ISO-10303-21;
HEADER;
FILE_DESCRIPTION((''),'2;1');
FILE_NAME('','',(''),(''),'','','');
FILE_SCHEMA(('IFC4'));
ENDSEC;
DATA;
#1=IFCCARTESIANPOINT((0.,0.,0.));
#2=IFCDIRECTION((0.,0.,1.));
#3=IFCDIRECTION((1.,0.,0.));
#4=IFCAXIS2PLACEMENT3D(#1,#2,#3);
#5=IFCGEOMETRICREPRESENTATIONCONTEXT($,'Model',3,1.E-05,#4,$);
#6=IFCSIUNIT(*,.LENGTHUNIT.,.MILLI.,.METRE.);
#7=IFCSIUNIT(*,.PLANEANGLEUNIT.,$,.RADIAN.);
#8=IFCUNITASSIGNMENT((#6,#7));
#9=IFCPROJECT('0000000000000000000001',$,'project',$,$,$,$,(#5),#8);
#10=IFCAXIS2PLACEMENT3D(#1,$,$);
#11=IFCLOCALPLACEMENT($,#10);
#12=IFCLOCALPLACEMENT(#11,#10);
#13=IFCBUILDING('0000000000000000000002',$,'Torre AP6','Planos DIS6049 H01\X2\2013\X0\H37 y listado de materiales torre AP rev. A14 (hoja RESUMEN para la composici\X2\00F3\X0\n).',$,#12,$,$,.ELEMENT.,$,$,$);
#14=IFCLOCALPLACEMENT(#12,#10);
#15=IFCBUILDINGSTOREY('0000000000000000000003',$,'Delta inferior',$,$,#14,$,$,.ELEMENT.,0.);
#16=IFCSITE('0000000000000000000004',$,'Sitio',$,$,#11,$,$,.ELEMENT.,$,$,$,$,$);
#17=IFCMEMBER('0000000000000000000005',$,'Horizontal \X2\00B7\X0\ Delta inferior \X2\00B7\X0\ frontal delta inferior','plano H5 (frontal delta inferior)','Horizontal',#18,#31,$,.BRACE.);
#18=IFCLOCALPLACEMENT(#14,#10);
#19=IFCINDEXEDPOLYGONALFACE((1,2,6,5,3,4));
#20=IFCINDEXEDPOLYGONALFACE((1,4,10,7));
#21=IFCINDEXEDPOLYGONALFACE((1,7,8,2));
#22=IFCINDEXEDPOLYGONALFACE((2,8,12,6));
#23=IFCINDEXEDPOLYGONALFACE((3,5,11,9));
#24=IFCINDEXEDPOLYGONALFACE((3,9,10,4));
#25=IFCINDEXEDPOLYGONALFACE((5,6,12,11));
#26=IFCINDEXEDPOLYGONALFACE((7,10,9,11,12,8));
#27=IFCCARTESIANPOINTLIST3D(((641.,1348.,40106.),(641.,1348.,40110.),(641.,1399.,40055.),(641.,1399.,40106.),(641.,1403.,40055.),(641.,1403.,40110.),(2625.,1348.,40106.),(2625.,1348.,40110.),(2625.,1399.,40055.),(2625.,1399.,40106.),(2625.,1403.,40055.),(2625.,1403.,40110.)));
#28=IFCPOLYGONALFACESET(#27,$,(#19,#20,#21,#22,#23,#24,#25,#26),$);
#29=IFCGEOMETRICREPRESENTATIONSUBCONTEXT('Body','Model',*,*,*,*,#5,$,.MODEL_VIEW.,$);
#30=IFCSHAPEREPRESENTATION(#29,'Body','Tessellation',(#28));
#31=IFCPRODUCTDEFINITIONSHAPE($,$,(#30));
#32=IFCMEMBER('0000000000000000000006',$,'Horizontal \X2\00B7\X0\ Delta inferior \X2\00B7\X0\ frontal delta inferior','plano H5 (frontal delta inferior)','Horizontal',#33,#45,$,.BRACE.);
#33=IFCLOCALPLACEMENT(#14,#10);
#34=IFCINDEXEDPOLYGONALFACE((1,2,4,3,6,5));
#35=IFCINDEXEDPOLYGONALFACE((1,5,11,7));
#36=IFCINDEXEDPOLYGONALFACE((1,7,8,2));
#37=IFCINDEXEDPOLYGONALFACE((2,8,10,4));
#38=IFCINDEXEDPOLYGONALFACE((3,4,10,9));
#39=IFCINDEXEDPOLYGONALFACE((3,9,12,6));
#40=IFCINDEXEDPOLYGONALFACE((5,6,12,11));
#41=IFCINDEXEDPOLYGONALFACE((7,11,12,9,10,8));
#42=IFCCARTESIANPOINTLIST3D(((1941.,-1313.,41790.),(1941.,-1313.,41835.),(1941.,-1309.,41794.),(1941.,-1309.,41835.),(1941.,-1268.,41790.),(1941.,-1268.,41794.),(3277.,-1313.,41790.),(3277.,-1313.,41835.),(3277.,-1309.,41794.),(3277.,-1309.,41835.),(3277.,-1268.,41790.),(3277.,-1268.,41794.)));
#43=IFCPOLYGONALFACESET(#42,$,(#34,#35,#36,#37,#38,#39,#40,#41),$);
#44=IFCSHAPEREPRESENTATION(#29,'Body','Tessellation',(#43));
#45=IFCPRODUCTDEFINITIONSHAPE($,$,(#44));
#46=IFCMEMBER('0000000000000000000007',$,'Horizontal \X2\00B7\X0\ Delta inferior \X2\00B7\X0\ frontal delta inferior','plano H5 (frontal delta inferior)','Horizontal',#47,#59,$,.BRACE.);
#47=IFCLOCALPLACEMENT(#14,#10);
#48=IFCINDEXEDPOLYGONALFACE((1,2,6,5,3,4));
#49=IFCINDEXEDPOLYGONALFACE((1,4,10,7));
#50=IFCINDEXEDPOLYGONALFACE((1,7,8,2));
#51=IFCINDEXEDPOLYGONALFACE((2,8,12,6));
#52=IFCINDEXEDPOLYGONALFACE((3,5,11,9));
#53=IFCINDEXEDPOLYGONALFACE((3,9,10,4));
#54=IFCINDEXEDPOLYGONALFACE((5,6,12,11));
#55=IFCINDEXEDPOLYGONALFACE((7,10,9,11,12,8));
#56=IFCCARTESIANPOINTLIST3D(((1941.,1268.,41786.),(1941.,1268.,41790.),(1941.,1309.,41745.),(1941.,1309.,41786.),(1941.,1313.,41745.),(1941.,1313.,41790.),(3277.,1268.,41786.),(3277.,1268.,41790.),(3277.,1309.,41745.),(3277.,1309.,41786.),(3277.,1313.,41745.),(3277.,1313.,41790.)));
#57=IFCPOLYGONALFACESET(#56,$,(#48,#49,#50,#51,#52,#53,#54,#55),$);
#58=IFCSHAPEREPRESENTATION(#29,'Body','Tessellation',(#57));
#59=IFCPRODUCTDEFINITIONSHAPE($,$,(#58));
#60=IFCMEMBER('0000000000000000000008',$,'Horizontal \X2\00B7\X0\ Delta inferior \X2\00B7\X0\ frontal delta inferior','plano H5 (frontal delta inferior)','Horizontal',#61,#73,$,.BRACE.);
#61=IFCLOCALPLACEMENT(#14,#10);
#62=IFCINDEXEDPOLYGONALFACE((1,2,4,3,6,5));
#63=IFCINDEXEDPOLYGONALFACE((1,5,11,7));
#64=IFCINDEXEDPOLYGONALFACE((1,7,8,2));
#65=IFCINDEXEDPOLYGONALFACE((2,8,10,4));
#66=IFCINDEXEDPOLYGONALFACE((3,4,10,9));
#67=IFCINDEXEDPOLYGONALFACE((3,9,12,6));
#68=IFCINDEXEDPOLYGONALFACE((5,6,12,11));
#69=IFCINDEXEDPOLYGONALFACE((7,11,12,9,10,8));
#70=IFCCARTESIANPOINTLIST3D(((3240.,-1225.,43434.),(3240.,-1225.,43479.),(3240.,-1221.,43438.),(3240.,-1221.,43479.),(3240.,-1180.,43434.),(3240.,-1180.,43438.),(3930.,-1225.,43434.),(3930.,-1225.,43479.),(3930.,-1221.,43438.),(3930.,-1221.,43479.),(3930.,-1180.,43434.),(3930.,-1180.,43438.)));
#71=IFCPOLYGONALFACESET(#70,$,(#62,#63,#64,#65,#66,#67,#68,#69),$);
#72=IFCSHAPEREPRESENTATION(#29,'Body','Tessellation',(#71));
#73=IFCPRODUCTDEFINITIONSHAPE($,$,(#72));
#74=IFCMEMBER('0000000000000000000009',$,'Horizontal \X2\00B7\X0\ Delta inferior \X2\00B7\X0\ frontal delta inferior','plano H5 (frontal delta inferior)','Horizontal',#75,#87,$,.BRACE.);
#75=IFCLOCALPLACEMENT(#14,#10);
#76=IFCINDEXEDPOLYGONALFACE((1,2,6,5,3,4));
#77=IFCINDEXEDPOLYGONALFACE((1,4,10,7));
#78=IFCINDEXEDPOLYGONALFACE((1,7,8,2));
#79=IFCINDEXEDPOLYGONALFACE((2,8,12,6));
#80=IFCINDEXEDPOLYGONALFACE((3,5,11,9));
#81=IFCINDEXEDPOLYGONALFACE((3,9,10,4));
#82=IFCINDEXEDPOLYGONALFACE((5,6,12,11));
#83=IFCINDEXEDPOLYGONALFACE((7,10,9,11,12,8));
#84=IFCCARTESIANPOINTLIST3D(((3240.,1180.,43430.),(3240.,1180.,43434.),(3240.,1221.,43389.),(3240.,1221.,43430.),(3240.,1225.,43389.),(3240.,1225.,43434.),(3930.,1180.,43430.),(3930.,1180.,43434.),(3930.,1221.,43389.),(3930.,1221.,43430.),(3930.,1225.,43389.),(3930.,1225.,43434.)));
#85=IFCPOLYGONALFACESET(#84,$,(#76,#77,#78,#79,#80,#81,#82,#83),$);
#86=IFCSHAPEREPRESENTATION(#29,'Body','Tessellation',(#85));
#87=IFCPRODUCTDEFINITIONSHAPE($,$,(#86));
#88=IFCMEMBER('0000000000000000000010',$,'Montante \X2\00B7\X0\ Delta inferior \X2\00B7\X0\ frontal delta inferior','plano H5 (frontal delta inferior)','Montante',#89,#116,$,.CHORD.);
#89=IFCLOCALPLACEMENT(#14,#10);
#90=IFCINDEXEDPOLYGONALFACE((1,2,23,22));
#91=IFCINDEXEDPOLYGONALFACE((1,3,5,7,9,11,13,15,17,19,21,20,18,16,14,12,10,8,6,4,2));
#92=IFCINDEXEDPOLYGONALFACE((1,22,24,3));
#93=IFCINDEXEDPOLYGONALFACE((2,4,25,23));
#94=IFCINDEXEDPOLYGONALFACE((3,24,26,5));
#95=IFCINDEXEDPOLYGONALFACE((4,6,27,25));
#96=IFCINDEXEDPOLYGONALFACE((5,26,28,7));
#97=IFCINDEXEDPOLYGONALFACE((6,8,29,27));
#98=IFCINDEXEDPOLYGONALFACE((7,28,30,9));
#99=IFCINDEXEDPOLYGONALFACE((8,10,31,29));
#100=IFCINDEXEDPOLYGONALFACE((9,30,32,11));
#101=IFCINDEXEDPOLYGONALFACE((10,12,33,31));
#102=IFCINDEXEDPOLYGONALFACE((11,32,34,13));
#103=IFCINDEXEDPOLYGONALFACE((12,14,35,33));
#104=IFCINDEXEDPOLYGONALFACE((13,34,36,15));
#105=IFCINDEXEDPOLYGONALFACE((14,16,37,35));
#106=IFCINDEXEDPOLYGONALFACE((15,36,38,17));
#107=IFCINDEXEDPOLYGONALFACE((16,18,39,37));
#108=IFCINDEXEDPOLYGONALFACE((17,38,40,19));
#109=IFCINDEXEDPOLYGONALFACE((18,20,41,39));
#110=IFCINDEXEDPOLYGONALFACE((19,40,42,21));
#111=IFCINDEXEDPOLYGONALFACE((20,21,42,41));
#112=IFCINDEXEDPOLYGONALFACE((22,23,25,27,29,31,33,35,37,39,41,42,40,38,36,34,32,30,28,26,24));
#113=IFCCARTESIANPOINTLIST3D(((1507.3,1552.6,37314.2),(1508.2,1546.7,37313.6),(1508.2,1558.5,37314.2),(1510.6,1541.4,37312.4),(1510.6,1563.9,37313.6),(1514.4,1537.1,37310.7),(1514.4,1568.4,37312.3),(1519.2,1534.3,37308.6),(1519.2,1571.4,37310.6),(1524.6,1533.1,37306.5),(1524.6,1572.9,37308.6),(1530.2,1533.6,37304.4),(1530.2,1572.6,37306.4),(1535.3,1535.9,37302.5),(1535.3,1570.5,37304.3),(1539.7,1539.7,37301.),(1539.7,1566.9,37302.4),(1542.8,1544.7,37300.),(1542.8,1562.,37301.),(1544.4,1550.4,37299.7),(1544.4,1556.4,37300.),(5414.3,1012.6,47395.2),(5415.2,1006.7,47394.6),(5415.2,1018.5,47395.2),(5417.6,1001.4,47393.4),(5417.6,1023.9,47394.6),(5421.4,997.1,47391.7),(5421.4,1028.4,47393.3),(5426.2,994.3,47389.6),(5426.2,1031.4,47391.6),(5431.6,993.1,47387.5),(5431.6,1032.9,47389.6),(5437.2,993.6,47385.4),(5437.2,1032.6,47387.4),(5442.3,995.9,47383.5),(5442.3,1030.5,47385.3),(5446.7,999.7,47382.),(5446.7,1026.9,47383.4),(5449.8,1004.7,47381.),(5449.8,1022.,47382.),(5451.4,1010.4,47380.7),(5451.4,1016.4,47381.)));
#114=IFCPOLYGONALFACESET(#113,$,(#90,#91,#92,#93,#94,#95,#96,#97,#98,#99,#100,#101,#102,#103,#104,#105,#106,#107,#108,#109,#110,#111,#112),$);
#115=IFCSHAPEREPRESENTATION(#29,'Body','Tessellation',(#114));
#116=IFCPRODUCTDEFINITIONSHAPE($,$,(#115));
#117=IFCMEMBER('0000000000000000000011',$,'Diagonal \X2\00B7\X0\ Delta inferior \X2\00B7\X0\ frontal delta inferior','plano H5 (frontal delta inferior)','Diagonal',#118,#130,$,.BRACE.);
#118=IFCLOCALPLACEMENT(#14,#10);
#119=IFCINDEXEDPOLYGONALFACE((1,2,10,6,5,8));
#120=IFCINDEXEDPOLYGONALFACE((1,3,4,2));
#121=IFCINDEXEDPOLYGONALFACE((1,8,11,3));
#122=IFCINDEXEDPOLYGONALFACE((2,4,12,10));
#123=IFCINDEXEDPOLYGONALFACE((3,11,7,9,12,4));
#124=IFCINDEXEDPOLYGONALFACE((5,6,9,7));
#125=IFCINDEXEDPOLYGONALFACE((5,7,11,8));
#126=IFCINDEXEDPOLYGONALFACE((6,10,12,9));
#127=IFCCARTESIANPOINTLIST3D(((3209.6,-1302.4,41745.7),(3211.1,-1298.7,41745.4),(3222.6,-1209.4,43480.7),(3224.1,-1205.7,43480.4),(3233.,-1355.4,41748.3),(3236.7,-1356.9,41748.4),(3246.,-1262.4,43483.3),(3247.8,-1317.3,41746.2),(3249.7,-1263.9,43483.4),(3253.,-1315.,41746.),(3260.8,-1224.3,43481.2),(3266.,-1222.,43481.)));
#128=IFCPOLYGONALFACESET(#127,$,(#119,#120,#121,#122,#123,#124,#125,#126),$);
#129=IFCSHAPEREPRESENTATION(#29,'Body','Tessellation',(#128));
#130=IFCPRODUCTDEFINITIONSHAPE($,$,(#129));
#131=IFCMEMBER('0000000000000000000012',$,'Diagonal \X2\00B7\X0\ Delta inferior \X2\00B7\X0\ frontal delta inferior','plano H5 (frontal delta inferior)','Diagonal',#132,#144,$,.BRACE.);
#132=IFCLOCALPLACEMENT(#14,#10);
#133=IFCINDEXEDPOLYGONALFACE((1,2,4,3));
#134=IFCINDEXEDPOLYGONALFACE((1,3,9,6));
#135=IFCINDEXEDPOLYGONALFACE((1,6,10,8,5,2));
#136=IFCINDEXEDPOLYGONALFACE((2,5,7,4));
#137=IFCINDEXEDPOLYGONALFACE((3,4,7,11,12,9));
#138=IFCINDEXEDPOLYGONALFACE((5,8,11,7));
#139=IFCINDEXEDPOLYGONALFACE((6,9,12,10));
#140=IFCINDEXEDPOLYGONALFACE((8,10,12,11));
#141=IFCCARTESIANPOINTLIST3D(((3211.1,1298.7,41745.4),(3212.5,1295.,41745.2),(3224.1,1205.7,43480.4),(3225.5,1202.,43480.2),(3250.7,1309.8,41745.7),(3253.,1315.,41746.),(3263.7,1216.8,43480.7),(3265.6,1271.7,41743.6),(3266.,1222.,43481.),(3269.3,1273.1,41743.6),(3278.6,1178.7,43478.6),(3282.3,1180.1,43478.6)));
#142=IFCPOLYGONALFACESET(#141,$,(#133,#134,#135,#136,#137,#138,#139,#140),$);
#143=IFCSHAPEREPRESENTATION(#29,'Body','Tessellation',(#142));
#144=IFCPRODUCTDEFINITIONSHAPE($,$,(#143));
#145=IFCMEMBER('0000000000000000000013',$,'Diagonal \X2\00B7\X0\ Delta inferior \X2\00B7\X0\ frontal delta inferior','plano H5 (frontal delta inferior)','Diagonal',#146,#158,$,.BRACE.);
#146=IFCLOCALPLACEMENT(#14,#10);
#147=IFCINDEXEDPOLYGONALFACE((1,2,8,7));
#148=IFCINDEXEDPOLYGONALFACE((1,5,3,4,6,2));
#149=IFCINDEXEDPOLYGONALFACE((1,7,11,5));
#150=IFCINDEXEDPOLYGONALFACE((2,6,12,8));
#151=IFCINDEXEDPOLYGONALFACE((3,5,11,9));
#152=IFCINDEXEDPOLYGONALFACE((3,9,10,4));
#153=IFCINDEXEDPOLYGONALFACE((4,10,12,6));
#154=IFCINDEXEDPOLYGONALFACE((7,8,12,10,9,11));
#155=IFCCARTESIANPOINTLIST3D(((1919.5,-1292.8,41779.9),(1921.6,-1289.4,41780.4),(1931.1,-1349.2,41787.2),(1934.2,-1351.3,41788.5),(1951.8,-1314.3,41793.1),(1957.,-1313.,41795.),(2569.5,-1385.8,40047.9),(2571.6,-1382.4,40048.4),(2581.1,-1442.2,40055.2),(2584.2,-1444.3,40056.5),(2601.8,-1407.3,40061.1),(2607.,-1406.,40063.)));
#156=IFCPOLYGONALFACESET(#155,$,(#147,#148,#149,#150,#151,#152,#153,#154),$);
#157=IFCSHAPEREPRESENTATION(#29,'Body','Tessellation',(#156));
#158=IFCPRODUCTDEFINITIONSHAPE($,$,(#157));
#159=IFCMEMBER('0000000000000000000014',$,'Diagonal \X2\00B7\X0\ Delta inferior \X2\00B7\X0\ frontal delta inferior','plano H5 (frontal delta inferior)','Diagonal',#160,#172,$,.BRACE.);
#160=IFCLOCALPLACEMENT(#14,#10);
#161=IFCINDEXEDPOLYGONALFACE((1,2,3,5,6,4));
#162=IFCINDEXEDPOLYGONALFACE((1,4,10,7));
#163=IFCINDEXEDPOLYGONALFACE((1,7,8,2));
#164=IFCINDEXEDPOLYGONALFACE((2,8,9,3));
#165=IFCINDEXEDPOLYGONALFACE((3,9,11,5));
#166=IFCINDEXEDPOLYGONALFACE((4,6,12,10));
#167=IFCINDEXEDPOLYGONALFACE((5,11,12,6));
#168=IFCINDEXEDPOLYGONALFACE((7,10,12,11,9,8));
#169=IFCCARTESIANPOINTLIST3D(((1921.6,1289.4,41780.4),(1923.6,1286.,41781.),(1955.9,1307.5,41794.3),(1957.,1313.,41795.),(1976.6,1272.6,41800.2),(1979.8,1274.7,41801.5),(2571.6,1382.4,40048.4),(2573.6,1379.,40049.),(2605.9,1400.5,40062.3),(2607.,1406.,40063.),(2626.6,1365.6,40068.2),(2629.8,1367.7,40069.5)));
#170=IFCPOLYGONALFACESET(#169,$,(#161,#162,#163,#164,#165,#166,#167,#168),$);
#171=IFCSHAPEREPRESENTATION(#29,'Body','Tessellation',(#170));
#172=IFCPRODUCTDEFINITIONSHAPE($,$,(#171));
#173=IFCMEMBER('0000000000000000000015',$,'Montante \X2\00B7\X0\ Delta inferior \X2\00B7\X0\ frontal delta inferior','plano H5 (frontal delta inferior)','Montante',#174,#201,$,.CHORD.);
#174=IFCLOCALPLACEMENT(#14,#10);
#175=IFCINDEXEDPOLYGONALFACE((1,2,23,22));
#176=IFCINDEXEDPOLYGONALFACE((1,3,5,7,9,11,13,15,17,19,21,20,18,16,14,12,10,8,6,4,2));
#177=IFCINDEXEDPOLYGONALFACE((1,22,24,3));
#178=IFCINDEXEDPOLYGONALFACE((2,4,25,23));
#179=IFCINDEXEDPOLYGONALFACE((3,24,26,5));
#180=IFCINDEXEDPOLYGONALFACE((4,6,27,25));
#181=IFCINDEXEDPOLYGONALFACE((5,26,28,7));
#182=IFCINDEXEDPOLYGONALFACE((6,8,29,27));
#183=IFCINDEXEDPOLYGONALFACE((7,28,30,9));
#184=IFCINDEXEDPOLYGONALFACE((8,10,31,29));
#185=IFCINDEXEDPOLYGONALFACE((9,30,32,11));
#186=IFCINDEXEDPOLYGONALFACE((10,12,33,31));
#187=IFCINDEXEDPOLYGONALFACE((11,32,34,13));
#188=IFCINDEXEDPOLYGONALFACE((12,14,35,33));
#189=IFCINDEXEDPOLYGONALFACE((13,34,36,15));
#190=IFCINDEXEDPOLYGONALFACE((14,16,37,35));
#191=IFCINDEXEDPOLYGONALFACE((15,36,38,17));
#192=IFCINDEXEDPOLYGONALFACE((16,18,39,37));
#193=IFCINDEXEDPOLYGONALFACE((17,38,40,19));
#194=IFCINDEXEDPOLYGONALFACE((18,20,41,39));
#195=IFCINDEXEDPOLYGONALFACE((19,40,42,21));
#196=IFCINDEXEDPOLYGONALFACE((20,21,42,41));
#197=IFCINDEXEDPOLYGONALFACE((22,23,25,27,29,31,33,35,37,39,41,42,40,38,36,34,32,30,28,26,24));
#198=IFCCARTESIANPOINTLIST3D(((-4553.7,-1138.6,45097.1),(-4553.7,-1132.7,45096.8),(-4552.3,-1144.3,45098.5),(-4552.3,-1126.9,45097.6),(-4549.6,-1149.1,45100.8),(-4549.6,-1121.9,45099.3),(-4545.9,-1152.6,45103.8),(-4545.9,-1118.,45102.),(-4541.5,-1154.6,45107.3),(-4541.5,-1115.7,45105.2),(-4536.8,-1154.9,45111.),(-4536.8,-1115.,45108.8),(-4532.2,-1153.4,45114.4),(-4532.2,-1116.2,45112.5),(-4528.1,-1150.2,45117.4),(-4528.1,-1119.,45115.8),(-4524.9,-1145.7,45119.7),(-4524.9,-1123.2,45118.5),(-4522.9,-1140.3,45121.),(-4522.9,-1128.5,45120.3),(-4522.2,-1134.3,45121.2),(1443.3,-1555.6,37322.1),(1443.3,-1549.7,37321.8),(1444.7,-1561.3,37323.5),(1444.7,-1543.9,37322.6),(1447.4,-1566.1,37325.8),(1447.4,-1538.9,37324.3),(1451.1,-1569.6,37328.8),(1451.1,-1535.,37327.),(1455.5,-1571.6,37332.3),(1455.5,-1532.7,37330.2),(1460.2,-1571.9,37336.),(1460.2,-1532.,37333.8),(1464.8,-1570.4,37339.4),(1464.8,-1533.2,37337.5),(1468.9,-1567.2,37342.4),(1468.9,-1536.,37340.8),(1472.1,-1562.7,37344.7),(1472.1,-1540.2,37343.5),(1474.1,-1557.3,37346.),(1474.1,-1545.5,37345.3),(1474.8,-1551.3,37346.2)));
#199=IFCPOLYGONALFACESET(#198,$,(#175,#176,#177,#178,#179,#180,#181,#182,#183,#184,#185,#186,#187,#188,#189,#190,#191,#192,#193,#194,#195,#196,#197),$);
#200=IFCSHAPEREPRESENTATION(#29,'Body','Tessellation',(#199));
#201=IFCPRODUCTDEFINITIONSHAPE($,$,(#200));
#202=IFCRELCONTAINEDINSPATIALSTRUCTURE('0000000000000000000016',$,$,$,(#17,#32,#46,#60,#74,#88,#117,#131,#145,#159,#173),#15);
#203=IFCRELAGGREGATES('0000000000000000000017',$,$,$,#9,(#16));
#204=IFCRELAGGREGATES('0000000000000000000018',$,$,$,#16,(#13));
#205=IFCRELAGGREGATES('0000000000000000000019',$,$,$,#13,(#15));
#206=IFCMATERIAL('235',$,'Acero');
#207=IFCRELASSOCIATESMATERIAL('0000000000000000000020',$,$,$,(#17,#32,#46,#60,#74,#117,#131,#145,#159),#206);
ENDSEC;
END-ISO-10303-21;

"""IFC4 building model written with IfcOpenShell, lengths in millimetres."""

from ifc_helpers import new_model, si_unit, frame, frame_2d, origin, origin_with_axes, place, context, subcontext, project, spatial, circle, l_section, extrude, material, element, save


model = new_model("IFC4")

# Units and contexts
model_context = context("Model", 3, precision=1e-05, world=origin_with_axes())
body_context = subcontext(model_context, "Body", "Model", "MODEL_VIEW")
ifc_project = project(units=[si_unit("LENGTHUNIT", "METRE", prefix="MILLI"), si_unit("PLANEANGLEUNIT", "RADIAN")], contexts=[model_context])

# Site, building, storey
site_placement = place(None, origin())
site = spatial("IfcSite", under=ifc_project, at=site_placement, Name="Sitio", CompositionType="ELEMENT")
building_placement = place(site_placement, origin())
building = spatial("IfcBuilding", under=site, at=building_placement, Name="Torre AP6", Description="Planos DIS6049 H01–H37 y listado de materiales torre AP rev. A14 (hoja RESUMEN para la composición).", CompositionType="ELEMENT")
storey_placement = place(building_placement, origin())
storey = spatial("IfcBuildingStorey", under=building, at=storey_placement, Name="Delta inferior", CompositionType="ELEMENT", Elevation=0.0)

# Members
ifc_material_1 = material(Name="235", Category="Acero")
member_1_placement = place(storey_placement, frame((641.0, 1403.0, 40110.0), z_axis=(1.0, 0.0, 0.0), x_axis=(0.0, -1.0, 0.0)))
element("IfcMember", 1, at=member_1_placement, inside=storey, material=ifc_material_1, Name="Horizontal · Delta inferior · frontal delta inferior", Description="plano H5 (frontal delta inferior)", ObjectType="Horizontal", PredefinedType="BRACE", context=body_context, shape_type="SweptSolid", body=[
    extrude(l_section(Depth=55.0, Width=55.0, Thickness=4.0, at=frame_2d((27.5, 27.5))), None, (0.0, 0.0, 1.0), 1984.0),
])
for number, where, z_axis, x_axis, name in (
    (2, (1941.0, -1313.0, 41790.0), (1.0, 0.0, 0.0), (0.0, 1.0, 0.0), "Horizontal · Delta inferior · frontal delta inferior"),
    (3, (1941.0, 1313.0, 41790.0), (1.0, 0.0, 0.0), (0.0, -1.0, 0.0), "Horizontal · Delta inferior · frontal delta inferior"),
):
    element("IfcMember", number, at=place(storey_placement, frame(where, z_axis=z_axis, x_axis=x_axis)), inside=storey, material=ifc_material_1, Name=name, Description="plano H5 (frontal delta inferior)", ObjectType="Horizontal", PredefinedType="BRACE", context=body_context, shape_type="SweptSolid", body=[
        extrude(l_section(Depth=45.0, Width=45.0, Thickness=4.0, at=frame_2d((22.5, 22.5))), None, (0.0, 0.0, 1.0), 1336.0),
    ])
for number, where, z_axis, x_axis, name in (
    (4, (3240.0, -1225.0, 43434.0), (1.0, 0.0, 0.0), (0.0, 1.0, 0.0), "Horizontal · Delta inferior · frontal delta inferior"),
    (5, (3240.0, 1225.0, 43434.0), (1.0, 0.0, 0.0), (0.0, -1.0, 0.0), "Horizontal · Delta inferior · frontal delta inferior"),
):
    element("IfcMember", number, at=place(storey_placement, frame(where, z_axis=z_axis, x_axis=x_axis)), inside=storey, material=ifc_material_1, Name=name, Description="plano H5 (frontal delta inferior)", ObjectType="Horizontal", PredefinedType="BRACE", context=body_context, shape_type="SweptSolid", body=[
        extrude(l_section(Depth=45.0, Width=45.0, Thickness=4.0, at=frame_2d((22.5, 22.5))), None, (0.0, 0.0, 1.0), 690.0),
    ])
for number, where, z_axis, x_axis, name in (
    (6, (1526.0, 1553.0, 37307.0), (0.36092, -0.049884, 0.931262), (-0.932597, -0.019305, 0.360404), "Montante · Delta inferior · frontal delta inferior"),
):
    element("IfcMember", number, at=place(storey_placement, frame(where, z_axis=z_axis, x_axis=x_axis)), inside=storey, Name=name, Description="plano H5 (frontal delta inferior)", ObjectType="Montante", PredefinedType="CHORD", context=body_context, shape_type="SweptSolid", body=[
        extrude(circle(Radius=20.0), None, (0.0, 0.0, 1.0), 10825.1),
    ])
for number, where, z_axis, x_axis, name in (
    (7, (3253.0, -1315.0, 41746.0), (0.007482, 0.053524, 0.998539), (-0.932081, 0.362036, -0.012422), "Diagonal · Delta inferior · frontal delta inferior"),
    (8, (3253.0, 1315.0, 41746.0), (0.007482, -0.053524, 0.998539), (-0.932081, -0.362036, -0.012422), "Diagonal · Delta inferior · frontal delta inferior"),
):
    element("IfcMember", number, at=place(storey_placement, frame(where, z_axis=z_axis, x_axis=x_axis)), inside=storey, material=ifc_material_1, Name=name, Description="plano H5 (frontal delta inferior)", ObjectType="Diagonal", PredefinedType="BRACE", context=body_context, shape_type="SweptSolid", body=[
        extrude(l_section(Depth=45.0, Width=45.0, Thickness=4.0, at=frame_2d((22.5, 22.5))), None, (0.0, 0.0, 1.0), 1737.5),
    ])
for number, where, z_axis, x_axis, name in (
    (9, (2607.0, -1406.0, 40063.0), (-0.350917, 0.050208, 0.935059), (-0.787637, 0.524232, -0.32374), "Diagonal · Delta inferior · frontal delta inferior"),
    (10, (2607.0, 1406.0, 40063.0), (-0.350917, -0.050208, 0.935059), (-0.787637, -0.524232, -0.32374), "Diagonal · Delta inferior · frontal delta inferior"),
):
    element("IfcMember", number, at=place(storey_placement, frame(where, z_axis=z_axis, x_axis=x_axis)), inside=storey, material=ifc_material_1, Name=name, Description="plano H5 (frontal delta inferior)", ObjectType="Diagonal", PredefinedType="BRACE", context=body_context, shape_type="SweptSolid", body=[
        extrude(l_section(Depth=45.0, Width=45.0, Thickness=4.0, at=frame_2d((22.5, 22.5))), None, (0.0, 0.0, 1.0), 1852.3),
    ])
for number, where, z_axis, x_axis, name in (
    (11, (1459.0, -1552.0, 37334.0), (-0.610199, 0.04243, 0.791111), (0.792248, 0.03268, 0.609323), "Montante · Delta inferior · frontal delta inferior"),
):
    element("IfcMember", number, at=place(storey_placement, frame(where, z_axis=z_axis, x_axis=x_axis)), inside=storey, Name=name, Description="plano H5 (frontal delta inferior)", ObjectType="Montante", PredefinedType="CHORD", context=body_context, shape_type="SweptSolid", body=[
        extrude(circle(Radius=20.0), None, (0.0, 0.0, 1.0), 9827.9),
    ])

save(model, "model.ifc")
